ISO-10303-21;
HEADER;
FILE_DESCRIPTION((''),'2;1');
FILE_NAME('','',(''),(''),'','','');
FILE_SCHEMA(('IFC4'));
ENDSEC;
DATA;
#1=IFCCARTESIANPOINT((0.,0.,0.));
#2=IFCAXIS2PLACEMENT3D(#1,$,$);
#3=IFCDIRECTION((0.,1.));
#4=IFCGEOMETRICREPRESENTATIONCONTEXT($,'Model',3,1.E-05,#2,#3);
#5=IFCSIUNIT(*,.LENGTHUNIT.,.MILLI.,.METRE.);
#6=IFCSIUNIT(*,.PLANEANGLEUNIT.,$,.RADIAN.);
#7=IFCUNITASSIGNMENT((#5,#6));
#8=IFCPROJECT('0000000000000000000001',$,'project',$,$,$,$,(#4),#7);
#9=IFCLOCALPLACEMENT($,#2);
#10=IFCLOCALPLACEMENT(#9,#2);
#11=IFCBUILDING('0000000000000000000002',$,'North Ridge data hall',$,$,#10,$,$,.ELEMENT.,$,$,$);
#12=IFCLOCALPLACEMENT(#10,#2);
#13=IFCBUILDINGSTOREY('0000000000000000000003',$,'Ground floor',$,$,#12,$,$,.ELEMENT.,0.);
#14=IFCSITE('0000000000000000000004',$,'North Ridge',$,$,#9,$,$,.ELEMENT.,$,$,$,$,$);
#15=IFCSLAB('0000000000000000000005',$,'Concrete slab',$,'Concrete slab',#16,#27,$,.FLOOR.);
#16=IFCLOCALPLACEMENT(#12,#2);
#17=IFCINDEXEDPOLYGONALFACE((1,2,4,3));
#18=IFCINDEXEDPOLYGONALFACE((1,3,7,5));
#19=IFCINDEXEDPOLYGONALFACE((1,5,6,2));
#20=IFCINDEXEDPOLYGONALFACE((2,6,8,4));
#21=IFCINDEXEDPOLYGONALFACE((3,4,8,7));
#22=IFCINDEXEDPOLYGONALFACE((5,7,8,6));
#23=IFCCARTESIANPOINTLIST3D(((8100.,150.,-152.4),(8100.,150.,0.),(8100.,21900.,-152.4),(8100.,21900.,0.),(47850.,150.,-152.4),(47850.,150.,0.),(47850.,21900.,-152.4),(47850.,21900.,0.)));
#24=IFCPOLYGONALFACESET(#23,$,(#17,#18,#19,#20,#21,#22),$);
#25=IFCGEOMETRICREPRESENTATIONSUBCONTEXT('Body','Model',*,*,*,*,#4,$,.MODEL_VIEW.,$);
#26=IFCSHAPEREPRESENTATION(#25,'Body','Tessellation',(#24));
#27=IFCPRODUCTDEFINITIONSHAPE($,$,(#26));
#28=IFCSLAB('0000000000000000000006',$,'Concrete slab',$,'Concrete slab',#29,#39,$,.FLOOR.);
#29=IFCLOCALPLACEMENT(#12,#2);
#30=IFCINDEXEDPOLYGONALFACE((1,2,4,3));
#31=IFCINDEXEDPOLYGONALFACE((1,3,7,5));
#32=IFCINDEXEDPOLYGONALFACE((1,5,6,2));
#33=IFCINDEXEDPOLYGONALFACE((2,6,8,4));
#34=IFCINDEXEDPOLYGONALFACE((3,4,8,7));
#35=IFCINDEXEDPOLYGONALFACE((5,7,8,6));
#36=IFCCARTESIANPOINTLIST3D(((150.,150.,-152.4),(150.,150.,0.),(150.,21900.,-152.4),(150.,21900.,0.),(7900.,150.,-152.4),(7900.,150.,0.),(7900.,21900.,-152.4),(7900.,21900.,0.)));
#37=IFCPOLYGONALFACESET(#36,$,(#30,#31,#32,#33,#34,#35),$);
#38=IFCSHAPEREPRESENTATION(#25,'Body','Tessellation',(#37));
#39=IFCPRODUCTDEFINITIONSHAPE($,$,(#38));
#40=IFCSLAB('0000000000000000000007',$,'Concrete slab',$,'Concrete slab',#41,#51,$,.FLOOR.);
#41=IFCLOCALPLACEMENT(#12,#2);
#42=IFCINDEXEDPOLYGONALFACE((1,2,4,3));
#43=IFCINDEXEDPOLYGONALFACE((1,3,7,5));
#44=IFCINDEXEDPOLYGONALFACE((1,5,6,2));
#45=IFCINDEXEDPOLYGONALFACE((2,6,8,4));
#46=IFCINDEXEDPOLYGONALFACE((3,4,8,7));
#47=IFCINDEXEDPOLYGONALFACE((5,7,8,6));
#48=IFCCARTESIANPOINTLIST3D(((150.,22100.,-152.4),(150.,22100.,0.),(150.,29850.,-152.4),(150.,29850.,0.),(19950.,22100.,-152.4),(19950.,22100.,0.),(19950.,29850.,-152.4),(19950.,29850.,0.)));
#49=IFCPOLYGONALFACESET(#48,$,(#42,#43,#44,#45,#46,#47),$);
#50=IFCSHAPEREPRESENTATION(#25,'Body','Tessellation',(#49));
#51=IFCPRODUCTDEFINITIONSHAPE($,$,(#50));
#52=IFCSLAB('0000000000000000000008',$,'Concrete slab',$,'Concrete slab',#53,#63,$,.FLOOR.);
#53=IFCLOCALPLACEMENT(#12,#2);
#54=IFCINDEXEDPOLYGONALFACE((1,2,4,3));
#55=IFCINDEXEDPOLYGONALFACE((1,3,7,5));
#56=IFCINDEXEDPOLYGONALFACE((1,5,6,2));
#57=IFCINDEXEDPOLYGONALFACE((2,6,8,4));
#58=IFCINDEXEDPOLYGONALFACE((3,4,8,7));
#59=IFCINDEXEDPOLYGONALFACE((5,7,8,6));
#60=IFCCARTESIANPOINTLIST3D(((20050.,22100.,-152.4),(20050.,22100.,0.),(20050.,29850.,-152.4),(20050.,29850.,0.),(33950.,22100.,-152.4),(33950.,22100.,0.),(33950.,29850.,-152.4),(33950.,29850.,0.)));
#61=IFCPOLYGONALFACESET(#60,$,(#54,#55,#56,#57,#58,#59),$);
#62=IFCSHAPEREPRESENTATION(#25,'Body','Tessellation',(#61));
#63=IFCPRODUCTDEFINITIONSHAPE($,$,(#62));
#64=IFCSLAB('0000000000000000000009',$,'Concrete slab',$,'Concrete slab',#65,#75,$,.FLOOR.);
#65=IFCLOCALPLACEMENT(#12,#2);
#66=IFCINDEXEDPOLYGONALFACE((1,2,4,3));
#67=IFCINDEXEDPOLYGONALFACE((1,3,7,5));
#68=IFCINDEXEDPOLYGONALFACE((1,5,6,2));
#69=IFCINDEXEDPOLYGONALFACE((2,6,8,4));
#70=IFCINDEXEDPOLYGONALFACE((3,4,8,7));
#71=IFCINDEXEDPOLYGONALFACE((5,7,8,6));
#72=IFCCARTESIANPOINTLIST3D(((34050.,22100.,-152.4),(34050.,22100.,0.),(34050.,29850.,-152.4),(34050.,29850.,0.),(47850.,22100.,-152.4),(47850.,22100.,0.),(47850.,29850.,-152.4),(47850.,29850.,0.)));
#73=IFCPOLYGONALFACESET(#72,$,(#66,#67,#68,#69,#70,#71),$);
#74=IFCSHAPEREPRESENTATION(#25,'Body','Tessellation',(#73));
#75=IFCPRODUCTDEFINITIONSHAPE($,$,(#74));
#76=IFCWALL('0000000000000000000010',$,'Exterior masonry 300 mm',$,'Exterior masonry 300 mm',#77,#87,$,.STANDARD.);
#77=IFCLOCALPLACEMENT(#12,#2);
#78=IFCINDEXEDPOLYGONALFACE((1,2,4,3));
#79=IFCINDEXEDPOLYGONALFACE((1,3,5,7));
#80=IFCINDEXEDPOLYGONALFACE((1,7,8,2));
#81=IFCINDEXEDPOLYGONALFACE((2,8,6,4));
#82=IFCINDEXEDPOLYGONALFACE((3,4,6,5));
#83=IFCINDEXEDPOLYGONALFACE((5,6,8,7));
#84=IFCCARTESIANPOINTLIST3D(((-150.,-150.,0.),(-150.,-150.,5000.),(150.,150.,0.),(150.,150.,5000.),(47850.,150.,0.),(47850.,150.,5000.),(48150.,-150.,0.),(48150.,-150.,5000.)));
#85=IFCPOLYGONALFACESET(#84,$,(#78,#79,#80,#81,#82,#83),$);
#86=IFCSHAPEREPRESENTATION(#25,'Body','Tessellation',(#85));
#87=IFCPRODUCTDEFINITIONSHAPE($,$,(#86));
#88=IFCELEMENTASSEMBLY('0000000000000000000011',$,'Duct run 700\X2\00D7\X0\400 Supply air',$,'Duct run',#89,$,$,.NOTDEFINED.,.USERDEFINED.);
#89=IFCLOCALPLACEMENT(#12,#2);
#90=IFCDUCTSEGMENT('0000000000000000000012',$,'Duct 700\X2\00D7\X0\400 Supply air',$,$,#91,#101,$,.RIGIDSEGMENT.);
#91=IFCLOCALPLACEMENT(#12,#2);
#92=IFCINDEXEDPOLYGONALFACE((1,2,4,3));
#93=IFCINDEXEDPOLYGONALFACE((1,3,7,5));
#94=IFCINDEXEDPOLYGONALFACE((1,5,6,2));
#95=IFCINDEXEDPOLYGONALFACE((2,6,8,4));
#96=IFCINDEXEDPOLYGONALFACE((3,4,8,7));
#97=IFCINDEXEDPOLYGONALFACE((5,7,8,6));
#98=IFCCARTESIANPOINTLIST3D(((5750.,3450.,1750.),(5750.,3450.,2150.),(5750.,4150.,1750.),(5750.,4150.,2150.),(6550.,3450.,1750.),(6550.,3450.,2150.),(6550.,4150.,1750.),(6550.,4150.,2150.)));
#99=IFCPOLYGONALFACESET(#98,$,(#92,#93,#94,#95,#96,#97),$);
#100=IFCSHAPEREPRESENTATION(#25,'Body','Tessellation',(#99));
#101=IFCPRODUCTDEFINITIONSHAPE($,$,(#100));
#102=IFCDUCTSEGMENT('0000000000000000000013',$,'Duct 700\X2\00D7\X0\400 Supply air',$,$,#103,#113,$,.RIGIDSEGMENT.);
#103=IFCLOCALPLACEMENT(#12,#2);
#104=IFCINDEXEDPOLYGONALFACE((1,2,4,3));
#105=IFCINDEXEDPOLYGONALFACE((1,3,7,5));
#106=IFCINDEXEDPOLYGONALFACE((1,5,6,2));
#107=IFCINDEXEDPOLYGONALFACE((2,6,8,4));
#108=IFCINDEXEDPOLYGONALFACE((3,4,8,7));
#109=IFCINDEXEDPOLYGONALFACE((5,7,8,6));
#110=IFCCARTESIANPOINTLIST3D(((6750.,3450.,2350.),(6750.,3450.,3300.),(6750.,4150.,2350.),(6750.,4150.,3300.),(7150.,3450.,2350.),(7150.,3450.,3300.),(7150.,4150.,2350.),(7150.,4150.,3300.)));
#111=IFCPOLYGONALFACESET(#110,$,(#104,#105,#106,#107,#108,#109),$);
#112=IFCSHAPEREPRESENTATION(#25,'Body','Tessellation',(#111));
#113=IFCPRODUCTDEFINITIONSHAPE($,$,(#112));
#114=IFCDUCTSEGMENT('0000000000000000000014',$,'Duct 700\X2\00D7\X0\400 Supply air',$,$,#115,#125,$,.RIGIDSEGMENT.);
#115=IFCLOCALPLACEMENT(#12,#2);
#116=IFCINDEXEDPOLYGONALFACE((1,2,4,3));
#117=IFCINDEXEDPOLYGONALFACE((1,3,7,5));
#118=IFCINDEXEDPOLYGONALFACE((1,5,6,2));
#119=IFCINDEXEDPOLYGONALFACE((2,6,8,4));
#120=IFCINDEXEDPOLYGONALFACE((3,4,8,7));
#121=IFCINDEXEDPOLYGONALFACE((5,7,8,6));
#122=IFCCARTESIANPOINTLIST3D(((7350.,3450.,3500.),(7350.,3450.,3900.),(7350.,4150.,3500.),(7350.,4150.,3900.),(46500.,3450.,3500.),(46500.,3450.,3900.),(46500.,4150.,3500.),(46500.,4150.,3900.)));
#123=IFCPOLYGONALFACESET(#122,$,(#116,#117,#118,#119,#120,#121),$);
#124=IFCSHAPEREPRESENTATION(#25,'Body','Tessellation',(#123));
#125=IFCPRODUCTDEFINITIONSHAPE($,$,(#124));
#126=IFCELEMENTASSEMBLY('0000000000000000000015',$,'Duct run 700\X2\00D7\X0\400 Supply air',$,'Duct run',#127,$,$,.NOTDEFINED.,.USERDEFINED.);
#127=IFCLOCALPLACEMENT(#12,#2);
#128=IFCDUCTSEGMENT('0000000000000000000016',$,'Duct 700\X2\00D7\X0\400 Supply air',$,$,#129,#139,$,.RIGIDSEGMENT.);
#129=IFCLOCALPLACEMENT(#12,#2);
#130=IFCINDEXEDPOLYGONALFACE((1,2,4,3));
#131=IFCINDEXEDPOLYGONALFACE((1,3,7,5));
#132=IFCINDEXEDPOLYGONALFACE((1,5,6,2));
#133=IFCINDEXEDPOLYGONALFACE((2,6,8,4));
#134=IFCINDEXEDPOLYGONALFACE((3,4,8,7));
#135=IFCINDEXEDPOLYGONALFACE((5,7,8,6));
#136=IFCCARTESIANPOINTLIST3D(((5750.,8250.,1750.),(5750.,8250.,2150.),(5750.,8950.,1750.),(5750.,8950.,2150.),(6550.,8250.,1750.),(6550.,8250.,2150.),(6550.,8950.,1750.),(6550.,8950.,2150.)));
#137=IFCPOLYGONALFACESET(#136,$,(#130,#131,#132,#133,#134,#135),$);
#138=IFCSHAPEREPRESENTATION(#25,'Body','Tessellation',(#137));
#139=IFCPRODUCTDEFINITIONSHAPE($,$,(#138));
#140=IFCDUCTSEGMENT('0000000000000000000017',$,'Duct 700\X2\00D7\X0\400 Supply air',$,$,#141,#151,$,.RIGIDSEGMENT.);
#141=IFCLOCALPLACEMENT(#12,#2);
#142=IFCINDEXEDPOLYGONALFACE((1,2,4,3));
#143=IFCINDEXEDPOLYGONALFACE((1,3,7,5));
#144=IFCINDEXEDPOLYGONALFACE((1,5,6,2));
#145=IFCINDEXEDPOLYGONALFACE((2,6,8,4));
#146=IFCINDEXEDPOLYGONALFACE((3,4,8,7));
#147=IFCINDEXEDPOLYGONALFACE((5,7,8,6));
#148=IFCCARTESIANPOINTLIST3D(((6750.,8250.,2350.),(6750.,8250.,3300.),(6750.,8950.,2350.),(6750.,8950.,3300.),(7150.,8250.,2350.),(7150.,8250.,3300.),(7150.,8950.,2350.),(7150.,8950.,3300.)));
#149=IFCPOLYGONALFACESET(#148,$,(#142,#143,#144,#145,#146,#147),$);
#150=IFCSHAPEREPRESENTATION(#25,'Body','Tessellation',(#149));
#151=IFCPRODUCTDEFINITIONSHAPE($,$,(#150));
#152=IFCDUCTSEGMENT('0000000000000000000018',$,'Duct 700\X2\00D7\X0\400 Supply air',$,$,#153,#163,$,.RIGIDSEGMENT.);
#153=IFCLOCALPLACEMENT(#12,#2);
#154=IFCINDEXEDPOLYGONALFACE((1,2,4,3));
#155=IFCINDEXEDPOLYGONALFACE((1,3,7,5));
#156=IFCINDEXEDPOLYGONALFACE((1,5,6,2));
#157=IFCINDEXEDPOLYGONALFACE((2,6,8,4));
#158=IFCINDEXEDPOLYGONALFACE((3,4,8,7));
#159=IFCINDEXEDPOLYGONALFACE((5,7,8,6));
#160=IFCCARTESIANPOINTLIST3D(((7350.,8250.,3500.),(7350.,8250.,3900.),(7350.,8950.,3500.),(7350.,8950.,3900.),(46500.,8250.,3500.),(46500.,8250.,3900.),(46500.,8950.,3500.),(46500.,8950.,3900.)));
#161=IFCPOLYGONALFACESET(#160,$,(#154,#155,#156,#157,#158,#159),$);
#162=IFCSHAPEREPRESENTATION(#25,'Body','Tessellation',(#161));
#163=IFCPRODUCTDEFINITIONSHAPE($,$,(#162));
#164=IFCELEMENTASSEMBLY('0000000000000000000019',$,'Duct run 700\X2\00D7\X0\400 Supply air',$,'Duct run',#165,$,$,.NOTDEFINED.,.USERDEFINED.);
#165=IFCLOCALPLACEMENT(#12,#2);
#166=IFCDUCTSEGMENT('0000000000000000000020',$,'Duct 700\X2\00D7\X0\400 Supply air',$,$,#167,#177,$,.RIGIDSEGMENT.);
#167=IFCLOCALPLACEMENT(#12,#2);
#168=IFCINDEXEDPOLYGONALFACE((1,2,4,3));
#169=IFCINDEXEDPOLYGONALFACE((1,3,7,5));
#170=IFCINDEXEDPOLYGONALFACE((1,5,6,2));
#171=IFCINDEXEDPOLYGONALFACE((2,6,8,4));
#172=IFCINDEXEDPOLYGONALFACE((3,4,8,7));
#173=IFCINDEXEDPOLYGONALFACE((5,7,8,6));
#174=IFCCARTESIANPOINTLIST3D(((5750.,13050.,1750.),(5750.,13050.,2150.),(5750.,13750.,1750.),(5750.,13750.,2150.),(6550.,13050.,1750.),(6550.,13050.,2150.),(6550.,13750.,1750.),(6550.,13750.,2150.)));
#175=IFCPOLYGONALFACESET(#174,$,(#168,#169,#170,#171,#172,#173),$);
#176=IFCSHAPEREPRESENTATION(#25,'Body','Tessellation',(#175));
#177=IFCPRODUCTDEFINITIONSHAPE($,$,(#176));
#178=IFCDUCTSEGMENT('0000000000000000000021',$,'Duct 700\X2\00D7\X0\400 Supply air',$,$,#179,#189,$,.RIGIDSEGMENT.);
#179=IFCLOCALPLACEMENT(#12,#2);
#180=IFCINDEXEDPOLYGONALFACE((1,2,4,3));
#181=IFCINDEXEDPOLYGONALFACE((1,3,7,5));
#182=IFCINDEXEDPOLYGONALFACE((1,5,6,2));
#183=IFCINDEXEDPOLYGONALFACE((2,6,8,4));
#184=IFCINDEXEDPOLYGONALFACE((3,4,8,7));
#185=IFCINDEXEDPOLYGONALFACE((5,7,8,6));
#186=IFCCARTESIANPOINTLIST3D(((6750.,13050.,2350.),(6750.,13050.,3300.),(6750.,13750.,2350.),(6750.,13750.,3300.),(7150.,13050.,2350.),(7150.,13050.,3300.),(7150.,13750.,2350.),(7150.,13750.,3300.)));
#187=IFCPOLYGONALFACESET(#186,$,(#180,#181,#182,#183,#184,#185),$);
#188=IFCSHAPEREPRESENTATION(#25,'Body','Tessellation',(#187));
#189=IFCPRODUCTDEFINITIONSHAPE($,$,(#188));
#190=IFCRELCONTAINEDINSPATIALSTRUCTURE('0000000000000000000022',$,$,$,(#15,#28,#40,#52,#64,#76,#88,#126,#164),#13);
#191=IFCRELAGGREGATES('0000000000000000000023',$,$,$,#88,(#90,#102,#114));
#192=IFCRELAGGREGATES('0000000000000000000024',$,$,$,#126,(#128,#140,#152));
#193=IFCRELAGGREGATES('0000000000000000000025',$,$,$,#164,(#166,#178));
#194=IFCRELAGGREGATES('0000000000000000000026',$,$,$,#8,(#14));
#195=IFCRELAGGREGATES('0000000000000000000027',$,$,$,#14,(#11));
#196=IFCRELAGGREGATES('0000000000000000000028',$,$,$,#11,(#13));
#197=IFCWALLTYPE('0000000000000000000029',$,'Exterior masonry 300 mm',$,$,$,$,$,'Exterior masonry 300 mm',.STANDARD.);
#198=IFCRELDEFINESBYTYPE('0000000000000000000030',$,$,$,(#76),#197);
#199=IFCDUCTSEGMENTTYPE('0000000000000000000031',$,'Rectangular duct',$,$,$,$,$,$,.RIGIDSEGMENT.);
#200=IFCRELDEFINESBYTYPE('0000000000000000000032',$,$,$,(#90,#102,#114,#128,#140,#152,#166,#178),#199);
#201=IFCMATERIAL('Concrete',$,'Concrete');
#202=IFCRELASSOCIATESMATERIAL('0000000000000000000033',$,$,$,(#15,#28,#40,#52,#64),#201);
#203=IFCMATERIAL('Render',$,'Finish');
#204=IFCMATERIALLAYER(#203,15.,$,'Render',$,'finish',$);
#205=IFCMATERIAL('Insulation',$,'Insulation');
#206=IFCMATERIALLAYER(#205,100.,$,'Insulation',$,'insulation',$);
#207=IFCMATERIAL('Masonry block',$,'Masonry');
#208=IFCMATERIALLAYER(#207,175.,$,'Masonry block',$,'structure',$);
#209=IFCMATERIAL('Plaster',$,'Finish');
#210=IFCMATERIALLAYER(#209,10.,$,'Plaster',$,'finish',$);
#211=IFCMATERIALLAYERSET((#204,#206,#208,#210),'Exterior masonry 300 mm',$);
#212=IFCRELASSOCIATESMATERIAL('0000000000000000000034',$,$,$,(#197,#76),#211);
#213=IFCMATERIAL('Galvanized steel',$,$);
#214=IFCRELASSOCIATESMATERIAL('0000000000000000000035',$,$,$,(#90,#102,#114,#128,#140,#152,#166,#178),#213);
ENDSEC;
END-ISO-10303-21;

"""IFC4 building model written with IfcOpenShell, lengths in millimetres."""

from ifc_helpers import new_model, si_unit, direction, frame, origin, origin_with_axes, origin_2d, place, context, subcontext, project, spatial, polyline, rectangle, outline, extrude, material, layer, layer_set, layer_usage, type_object, element, aggregate, save


model = new_model("IFC4")

# Units and contexts
model_context = context("Model", 3, precision=1e-05, world=origin(), true_north=direction((0.0, 1.0)))
body_context = subcontext(model_context, "Body", "Model", "MODEL_VIEW")
ifc_project = project(units=[si_unit("LENGTHUNIT", "METRE", prefix="MILLI"), si_unit("PLANEANGLEUNIT", "RADIAN")], contexts=[model_context])

# Site, building, storey
site_placement = place(None, origin())
site = spatial("IfcSite", under=ifc_project, at=site_placement, Name="North Ridge", CompositionType="ELEMENT")
building_placement = place(site_placement, origin())
building = spatial("IfcBuilding", under=site, at=building_placement, Name="North Ridge data hall", CompositionType="ELEMENT")
storey_placement = place(building_placement, origin())
storey = spatial("IfcBuildingStorey", under=building, at=storey_placement, Name="Ground floor", CompositionType="ELEMENT", Elevation=0.0)

# Slabs
ifc_material_1 = material(Name="Concrete", Category="Concrete")
slab_1_placement = place(storey_placement, origin_with_axes())
element("IfcSlab", 1, at=slab_1_placement, inside=storey, material=ifc_material_1, Name="Concrete slab", ObjectType="Concrete slab", PredefinedType="FLOOR", context=body_context, shape_type="SweptSolid", body=[
    extrude(outline(polyline([(8100.0, 150.0), (47850.0, 150.0), (47850.0, 21900.0), (8100.0, 21900.0), (8100.0, 150.0)])), frame((0.0, 0.0, -152.4)), (0.0, 0.0, 1.0), 152.4),
])
slab_2_placement = place(storey_placement, origin_with_axes())
element("IfcSlab", 2, at=slab_2_placement, inside=storey, material=ifc_material_1, Name="Concrete slab", ObjectType="Concrete slab", PredefinedType="FLOOR", context=body_context, shape_type="SweptSolid", body=[
    extrude(outline(polyline([(150.0, 150.0), (7900.0, 150.0), (7900.0, 21900.0), (150.0, 21900.0), (150.0, 150.0)])), frame((0.0, 0.0, -152.4)), (0.0, 0.0, 1.0), 152.4),
])
slab_3_placement = place(storey_placement, origin_with_axes())
element("IfcSlab", 3, at=slab_3_placement, inside=storey, material=ifc_material_1, Name="Concrete slab", ObjectType="Concrete slab", PredefinedType="FLOOR", context=body_context, shape_type="SweptSolid", body=[
    extrude(outline(polyline([(19950.0, 29850.0), (150.0, 29850.0), (150.0, 22100.0), (19950.0, 22100.0), (19950.0, 29850.0)])), frame((0.0, 0.0, -152.4)), (0.0, 0.0, 1.0), 152.4),
])
slab_4_placement = place(storey_placement, origin_with_axes())
element("IfcSlab", 4, at=slab_4_placement, inside=storey, material=ifc_material_1, Name="Concrete slab", ObjectType="Concrete slab", PredefinedType="FLOOR", context=body_context, shape_type="SweptSolid", body=[
    extrude(outline(polyline([(33950.0, 29850.0), (20050.0, 29850.0), (20050.0, 22100.0), (33950.0, 22100.0), (33950.0, 29850.0)])), frame((0.0, 0.0, -152.4)), (0.0, 0.0, 1.0), 152.4),
])
slab_5_placement = place(storey_placement, origin_with_axes())
element("IfcSlab", 5, at=slab_5_placement, inside=storey, material=ifc_material_1, Name="Concrete slab", ObjectType="Concrete slab", PredefinedType="FLOOR", context=body_context, shape_type="SweptSolid", body=[
    extrude(outline(polyline([(47850.0, 22100.0), (47850.0, 29850.0), (34050.0, 29850.0), (34050.0, 22100.0), (47850.0, 22100.0)])), frame((0.0, 0.0, -152.4)), (0.0, 0.0, 1.0), 152.4),
])

# Wall
ifc_material_2 = material(Name="Render", Category="Finish")
ifc_layer_1 = layer(ifc_material_2, 15.0, Name="Render", Category="finish")
ifc_material_3 = material(Name="Insulation", Category="Insulation")
ifc_layer_2 = layer(ifc_material_3, 100.0, Name="Insulation", Category="insulation")
ifc_material_4 = material(Name="Masonry block", Category="Masonry")
ifc_layer_3 = layer(ifc_material_4, 175.0, Name="Masonry block", Category="structure")
ifc_material_5 = material(Name="Plaster", Category="Finish")
ifc_layer_4 = layer(ifc_material_5, 10.0, Name="Plaster", Category="finish")
ifc_layer_set = layer_set([ifc_layer_1, ifc_layer_2, ifc_layer_3, ifc_layer_4], Name="Exterior masonry 300 mm")
ifc_layer_usage = layer_usage(ifc_layer_set, "AXIS2", "POSITIVE", -150.0)
wall_type = type_object("IfcWallType", Name="Exterior masonry 300 mm", ElementType="Exterior masonry 300 mm", PredefinedType="STANDARD", material=ifc_layer_set)
wall_placement = place(storey_placement, origin_with_axes())
element("IfcWall", 6, at=wall_placement, inside=storey, type_object=wall_type, material=ifc_layer_usage, Name="Exterior masonry 300 mm", ObjectType="Exterior masonry 300 mm", PredefinedType="STANDARD", context=body_context, shape_type="SweptSolid", body=[
    extrude(outline(polyline([(-150.0, -150.0), (48150.0, -150.0), (47850.0, 150.0), (150.0, 150.0), (-150.0, -150.0)])), origin(), (0.0, 0.0, 1.0), 5000.0),
])

# Element assemblies, duct segments
assembly_1_placement = place(storey_placement, origin_with_axes())
assembly_1 = element("IfcElementAssembly", 7, at=assembly_1_placement, inside=storey, Name="Duct run 700×400 Supply air", ObjectType="Duct run", AssemblyPlace="NOTDEFINED", PredefinedType="USERDEFINED")
ifc_material_6 = material(Name="Galvanized steel")
duct_segment_type = type_object("IfcDuctSegmentType", Name="Rectangular duct", PredefinedType="RIGIDSEGMENT")
duct_segment_1_placement = place(storey_placement, origin_with_axes())
duct_segment_1 = element("IfcDuctSegment", 8, at=duct_segment_1_placement, type_object=duct_segment_type, material=ifc_material_6, Name="Duct 700×400 Supply air", PredefinedType="RIGIDSEGMENT", context=body_context, shape_type="SweptSolid", body=[
    extrude(rectangle(XDim=700.0, YDim=400.0, at=origin_2d()), frame((5750.0, 3800.0, 1950.0), z_axis=(1.0, 0.0, 0.0), x_axis=(0.0, 1.0, 0.0)), (0.0, 0.0, 1.0), 800.0),
])
duct_segment_2_placement = place(storey_placement, origin_with_axes())
duct_segment_2 = element("IfcDuctSegment", 9, at=duct_segment_2_placement, type_object=duct_segment_type, material=ifc_material_6, Name="Duct 700×400 Supply air", PredefinedType="RIGIDSEGMENT", context=body_context, shape_type="SweptSolid", body=[
    extrude(rectangle(XDim=700.0, YDim=400.0, at=origin_2d()), frame((6950.0, 3800.0, 2350.0), z_axis=(0.0, 0.0, 1.0), x_axis=(0.0, 1.0, 0.0)), (0.0, 0.0, 1.0), 950.0),
])
duct_segment_3_placement = place(storey_placement, origin_with_axes())
duct_segment_3 = element("IfcDuctSegment", 10, at=duct_segment_3_placement, type_object=duct_segment_type, material=ifc_material_6, Name="Duct 700×400 Supply air", PredefinedType="RIGIDSEGMENT", context=body_context, shape_type="SweptSolid", body=[
    extrude(rectangle(XDim=700.0, YDim=400.0, at=origin_2d()), frame((7350.0, 3800.0, 3700.0), z_axis=(1.0, 0.0, 0.0), x_axis=(0.0, 1.0, 0.0)), (0.0, 0.0, 1.0), 39150.0),
])
assembly_2_placement = place(storey_placement, origin_with_axes())
assembly_2 = element("IfcElementAssembly", 11, at=assembly_2_placement, inside=storey, Name="Duct run 700×400 Supply air", ObjectType="Duct run", AssemblyPlace="NOTDEFINED", PredefinedType="USERDEFINED")
duct_segment_4_placement = place(storey_placement, origin_with_axes())
duct_segment_4 = element("IfcDuctSegment", 12, at=duct_segment_4_placement, type_object=duct_segment_type, material=ifc_material_6, Name="Duct 700×400 Supply air", PredefinedType="RIGIDSEGMENT", context=body_context, shape_type="SweptSolid", body=[
    extrude(rectangle(XDim=700.0, YDim=400.0, at=origin_2d()), frame((5750.0, 8600.0, 1950.0), z_axis=(1.0, 0.0, 0.0), x_axis=(0.0, 1.0, 0.0)), (0.0, 0.0, 1.0), 800.0),
])
duct_segment_5_placement = place(storey_placement, origin_with_axes())
duct_segment_5 = element("IfcDuctSegment", 13, at=duct_segment_5_placement, type_object=duct_segment_type, material=ifc_material_6, Name="Duct 700×400 Supply air", PredefinedType="RIGIDSEGMENT", context=body_context, shape_type="SweptSolid", body=[
    extrude(rectangle(XDim=700.0, YDim=400.0, at=origin_2d()), frame((6950.0, 8600.0, 2350.0), z_axis=(0.0, 0.0, 1.0), x_axis=(0.0, 1.0, 0.0)), (0.0, 0.0, 1.0), 950.0),
])
duct_segment_6_placement = place(storey_placement, origin_with_axes())
duct_segment_6 = element("IfcDuctSegment", 14, at=duct_segment_6_placement, type_object=duct_segment_type, material=ifc_material_6, Name="Duct 700×400 Supply air", PredefinedType="RIGIDSEGMENT", context=body_context, shape_type="SweptSolid", body=[
    extrude(rectangle(XDim=700.0, YDim=400.0, at=origin_2d()), frame((7350.0, 8600.0, 3700.0), z_axis=(1.0, 0.0, 0.0), x_axis=(0.0, 1.0, 0.0)), (0.0, 0.0, 1.0), 39150.0),
])
assembly_3_placement = place(storey_placement, origin_with_axes())
assembly_3 = element("IfcElementAssembly", 15, at=assembly_3_placement, inside=storey, Name="Duct run 700×400 Supply air", ObjectType="Duct run", AssemblyPlace="NOTDEFINED", PredefinedType="USERDEFINED")
duct_segment_7_placement = place(storey_placement, origin_with_axes())
duct_segment_7 = element("IfcDuctSegment", 16, at=duct_segment_7_placement, type_object=duct_segment_type, material=ifc_material_6, Name="Duct 700×400 Supply air", PredefinedType="RIGIDSEGMENT", context=body_context, shape_type="SweptSolid", body=[
    extrude(rectangle(XDim=700.0, YDim=400.0, at=origin_2d()), frame((5750.0, 13400.0, 1950.0), z_axis=(1.0, 0.0, 0.0), x_axis=(0.0, 1.0, 0.0)), (0.0, 0.0, 1.0), 800.0),
])
duct_segment_8_placement = place(storey_placement, origin_with_axes())
duct_segment_8 = element("IfcDuctSegment", 17, at=duct_segment_8_placement, type_object=duct_segment_type, material=ifc_material_6, Name="Duct 700×400 Supply air", PredefinedType="RIGIDSEGMENT", context=body_context, shape_type="SweptSolid", body=[
    extrude(rectangle(XDim=700.0, YDim=400.0, at=origin_2d()), frame((6950.0, 13400.0, 2350.0), z_axis=(0.0, 0.0, 1.0), x_axis=(0.0, 1.0, 0.0)), (0.0, 0.0, 1.0), 950.0),
])

aggregate(assembly_1, [duct_segment_1, duct_segment_2, duct_segment_3])
aggregate(assembly_2, [duct_segment_4, duct_segment_5, duct_segment_6])
aggregate(assembly_3, [duct_segment_7, duct_segment_8])

save(model, "model.ifc")
